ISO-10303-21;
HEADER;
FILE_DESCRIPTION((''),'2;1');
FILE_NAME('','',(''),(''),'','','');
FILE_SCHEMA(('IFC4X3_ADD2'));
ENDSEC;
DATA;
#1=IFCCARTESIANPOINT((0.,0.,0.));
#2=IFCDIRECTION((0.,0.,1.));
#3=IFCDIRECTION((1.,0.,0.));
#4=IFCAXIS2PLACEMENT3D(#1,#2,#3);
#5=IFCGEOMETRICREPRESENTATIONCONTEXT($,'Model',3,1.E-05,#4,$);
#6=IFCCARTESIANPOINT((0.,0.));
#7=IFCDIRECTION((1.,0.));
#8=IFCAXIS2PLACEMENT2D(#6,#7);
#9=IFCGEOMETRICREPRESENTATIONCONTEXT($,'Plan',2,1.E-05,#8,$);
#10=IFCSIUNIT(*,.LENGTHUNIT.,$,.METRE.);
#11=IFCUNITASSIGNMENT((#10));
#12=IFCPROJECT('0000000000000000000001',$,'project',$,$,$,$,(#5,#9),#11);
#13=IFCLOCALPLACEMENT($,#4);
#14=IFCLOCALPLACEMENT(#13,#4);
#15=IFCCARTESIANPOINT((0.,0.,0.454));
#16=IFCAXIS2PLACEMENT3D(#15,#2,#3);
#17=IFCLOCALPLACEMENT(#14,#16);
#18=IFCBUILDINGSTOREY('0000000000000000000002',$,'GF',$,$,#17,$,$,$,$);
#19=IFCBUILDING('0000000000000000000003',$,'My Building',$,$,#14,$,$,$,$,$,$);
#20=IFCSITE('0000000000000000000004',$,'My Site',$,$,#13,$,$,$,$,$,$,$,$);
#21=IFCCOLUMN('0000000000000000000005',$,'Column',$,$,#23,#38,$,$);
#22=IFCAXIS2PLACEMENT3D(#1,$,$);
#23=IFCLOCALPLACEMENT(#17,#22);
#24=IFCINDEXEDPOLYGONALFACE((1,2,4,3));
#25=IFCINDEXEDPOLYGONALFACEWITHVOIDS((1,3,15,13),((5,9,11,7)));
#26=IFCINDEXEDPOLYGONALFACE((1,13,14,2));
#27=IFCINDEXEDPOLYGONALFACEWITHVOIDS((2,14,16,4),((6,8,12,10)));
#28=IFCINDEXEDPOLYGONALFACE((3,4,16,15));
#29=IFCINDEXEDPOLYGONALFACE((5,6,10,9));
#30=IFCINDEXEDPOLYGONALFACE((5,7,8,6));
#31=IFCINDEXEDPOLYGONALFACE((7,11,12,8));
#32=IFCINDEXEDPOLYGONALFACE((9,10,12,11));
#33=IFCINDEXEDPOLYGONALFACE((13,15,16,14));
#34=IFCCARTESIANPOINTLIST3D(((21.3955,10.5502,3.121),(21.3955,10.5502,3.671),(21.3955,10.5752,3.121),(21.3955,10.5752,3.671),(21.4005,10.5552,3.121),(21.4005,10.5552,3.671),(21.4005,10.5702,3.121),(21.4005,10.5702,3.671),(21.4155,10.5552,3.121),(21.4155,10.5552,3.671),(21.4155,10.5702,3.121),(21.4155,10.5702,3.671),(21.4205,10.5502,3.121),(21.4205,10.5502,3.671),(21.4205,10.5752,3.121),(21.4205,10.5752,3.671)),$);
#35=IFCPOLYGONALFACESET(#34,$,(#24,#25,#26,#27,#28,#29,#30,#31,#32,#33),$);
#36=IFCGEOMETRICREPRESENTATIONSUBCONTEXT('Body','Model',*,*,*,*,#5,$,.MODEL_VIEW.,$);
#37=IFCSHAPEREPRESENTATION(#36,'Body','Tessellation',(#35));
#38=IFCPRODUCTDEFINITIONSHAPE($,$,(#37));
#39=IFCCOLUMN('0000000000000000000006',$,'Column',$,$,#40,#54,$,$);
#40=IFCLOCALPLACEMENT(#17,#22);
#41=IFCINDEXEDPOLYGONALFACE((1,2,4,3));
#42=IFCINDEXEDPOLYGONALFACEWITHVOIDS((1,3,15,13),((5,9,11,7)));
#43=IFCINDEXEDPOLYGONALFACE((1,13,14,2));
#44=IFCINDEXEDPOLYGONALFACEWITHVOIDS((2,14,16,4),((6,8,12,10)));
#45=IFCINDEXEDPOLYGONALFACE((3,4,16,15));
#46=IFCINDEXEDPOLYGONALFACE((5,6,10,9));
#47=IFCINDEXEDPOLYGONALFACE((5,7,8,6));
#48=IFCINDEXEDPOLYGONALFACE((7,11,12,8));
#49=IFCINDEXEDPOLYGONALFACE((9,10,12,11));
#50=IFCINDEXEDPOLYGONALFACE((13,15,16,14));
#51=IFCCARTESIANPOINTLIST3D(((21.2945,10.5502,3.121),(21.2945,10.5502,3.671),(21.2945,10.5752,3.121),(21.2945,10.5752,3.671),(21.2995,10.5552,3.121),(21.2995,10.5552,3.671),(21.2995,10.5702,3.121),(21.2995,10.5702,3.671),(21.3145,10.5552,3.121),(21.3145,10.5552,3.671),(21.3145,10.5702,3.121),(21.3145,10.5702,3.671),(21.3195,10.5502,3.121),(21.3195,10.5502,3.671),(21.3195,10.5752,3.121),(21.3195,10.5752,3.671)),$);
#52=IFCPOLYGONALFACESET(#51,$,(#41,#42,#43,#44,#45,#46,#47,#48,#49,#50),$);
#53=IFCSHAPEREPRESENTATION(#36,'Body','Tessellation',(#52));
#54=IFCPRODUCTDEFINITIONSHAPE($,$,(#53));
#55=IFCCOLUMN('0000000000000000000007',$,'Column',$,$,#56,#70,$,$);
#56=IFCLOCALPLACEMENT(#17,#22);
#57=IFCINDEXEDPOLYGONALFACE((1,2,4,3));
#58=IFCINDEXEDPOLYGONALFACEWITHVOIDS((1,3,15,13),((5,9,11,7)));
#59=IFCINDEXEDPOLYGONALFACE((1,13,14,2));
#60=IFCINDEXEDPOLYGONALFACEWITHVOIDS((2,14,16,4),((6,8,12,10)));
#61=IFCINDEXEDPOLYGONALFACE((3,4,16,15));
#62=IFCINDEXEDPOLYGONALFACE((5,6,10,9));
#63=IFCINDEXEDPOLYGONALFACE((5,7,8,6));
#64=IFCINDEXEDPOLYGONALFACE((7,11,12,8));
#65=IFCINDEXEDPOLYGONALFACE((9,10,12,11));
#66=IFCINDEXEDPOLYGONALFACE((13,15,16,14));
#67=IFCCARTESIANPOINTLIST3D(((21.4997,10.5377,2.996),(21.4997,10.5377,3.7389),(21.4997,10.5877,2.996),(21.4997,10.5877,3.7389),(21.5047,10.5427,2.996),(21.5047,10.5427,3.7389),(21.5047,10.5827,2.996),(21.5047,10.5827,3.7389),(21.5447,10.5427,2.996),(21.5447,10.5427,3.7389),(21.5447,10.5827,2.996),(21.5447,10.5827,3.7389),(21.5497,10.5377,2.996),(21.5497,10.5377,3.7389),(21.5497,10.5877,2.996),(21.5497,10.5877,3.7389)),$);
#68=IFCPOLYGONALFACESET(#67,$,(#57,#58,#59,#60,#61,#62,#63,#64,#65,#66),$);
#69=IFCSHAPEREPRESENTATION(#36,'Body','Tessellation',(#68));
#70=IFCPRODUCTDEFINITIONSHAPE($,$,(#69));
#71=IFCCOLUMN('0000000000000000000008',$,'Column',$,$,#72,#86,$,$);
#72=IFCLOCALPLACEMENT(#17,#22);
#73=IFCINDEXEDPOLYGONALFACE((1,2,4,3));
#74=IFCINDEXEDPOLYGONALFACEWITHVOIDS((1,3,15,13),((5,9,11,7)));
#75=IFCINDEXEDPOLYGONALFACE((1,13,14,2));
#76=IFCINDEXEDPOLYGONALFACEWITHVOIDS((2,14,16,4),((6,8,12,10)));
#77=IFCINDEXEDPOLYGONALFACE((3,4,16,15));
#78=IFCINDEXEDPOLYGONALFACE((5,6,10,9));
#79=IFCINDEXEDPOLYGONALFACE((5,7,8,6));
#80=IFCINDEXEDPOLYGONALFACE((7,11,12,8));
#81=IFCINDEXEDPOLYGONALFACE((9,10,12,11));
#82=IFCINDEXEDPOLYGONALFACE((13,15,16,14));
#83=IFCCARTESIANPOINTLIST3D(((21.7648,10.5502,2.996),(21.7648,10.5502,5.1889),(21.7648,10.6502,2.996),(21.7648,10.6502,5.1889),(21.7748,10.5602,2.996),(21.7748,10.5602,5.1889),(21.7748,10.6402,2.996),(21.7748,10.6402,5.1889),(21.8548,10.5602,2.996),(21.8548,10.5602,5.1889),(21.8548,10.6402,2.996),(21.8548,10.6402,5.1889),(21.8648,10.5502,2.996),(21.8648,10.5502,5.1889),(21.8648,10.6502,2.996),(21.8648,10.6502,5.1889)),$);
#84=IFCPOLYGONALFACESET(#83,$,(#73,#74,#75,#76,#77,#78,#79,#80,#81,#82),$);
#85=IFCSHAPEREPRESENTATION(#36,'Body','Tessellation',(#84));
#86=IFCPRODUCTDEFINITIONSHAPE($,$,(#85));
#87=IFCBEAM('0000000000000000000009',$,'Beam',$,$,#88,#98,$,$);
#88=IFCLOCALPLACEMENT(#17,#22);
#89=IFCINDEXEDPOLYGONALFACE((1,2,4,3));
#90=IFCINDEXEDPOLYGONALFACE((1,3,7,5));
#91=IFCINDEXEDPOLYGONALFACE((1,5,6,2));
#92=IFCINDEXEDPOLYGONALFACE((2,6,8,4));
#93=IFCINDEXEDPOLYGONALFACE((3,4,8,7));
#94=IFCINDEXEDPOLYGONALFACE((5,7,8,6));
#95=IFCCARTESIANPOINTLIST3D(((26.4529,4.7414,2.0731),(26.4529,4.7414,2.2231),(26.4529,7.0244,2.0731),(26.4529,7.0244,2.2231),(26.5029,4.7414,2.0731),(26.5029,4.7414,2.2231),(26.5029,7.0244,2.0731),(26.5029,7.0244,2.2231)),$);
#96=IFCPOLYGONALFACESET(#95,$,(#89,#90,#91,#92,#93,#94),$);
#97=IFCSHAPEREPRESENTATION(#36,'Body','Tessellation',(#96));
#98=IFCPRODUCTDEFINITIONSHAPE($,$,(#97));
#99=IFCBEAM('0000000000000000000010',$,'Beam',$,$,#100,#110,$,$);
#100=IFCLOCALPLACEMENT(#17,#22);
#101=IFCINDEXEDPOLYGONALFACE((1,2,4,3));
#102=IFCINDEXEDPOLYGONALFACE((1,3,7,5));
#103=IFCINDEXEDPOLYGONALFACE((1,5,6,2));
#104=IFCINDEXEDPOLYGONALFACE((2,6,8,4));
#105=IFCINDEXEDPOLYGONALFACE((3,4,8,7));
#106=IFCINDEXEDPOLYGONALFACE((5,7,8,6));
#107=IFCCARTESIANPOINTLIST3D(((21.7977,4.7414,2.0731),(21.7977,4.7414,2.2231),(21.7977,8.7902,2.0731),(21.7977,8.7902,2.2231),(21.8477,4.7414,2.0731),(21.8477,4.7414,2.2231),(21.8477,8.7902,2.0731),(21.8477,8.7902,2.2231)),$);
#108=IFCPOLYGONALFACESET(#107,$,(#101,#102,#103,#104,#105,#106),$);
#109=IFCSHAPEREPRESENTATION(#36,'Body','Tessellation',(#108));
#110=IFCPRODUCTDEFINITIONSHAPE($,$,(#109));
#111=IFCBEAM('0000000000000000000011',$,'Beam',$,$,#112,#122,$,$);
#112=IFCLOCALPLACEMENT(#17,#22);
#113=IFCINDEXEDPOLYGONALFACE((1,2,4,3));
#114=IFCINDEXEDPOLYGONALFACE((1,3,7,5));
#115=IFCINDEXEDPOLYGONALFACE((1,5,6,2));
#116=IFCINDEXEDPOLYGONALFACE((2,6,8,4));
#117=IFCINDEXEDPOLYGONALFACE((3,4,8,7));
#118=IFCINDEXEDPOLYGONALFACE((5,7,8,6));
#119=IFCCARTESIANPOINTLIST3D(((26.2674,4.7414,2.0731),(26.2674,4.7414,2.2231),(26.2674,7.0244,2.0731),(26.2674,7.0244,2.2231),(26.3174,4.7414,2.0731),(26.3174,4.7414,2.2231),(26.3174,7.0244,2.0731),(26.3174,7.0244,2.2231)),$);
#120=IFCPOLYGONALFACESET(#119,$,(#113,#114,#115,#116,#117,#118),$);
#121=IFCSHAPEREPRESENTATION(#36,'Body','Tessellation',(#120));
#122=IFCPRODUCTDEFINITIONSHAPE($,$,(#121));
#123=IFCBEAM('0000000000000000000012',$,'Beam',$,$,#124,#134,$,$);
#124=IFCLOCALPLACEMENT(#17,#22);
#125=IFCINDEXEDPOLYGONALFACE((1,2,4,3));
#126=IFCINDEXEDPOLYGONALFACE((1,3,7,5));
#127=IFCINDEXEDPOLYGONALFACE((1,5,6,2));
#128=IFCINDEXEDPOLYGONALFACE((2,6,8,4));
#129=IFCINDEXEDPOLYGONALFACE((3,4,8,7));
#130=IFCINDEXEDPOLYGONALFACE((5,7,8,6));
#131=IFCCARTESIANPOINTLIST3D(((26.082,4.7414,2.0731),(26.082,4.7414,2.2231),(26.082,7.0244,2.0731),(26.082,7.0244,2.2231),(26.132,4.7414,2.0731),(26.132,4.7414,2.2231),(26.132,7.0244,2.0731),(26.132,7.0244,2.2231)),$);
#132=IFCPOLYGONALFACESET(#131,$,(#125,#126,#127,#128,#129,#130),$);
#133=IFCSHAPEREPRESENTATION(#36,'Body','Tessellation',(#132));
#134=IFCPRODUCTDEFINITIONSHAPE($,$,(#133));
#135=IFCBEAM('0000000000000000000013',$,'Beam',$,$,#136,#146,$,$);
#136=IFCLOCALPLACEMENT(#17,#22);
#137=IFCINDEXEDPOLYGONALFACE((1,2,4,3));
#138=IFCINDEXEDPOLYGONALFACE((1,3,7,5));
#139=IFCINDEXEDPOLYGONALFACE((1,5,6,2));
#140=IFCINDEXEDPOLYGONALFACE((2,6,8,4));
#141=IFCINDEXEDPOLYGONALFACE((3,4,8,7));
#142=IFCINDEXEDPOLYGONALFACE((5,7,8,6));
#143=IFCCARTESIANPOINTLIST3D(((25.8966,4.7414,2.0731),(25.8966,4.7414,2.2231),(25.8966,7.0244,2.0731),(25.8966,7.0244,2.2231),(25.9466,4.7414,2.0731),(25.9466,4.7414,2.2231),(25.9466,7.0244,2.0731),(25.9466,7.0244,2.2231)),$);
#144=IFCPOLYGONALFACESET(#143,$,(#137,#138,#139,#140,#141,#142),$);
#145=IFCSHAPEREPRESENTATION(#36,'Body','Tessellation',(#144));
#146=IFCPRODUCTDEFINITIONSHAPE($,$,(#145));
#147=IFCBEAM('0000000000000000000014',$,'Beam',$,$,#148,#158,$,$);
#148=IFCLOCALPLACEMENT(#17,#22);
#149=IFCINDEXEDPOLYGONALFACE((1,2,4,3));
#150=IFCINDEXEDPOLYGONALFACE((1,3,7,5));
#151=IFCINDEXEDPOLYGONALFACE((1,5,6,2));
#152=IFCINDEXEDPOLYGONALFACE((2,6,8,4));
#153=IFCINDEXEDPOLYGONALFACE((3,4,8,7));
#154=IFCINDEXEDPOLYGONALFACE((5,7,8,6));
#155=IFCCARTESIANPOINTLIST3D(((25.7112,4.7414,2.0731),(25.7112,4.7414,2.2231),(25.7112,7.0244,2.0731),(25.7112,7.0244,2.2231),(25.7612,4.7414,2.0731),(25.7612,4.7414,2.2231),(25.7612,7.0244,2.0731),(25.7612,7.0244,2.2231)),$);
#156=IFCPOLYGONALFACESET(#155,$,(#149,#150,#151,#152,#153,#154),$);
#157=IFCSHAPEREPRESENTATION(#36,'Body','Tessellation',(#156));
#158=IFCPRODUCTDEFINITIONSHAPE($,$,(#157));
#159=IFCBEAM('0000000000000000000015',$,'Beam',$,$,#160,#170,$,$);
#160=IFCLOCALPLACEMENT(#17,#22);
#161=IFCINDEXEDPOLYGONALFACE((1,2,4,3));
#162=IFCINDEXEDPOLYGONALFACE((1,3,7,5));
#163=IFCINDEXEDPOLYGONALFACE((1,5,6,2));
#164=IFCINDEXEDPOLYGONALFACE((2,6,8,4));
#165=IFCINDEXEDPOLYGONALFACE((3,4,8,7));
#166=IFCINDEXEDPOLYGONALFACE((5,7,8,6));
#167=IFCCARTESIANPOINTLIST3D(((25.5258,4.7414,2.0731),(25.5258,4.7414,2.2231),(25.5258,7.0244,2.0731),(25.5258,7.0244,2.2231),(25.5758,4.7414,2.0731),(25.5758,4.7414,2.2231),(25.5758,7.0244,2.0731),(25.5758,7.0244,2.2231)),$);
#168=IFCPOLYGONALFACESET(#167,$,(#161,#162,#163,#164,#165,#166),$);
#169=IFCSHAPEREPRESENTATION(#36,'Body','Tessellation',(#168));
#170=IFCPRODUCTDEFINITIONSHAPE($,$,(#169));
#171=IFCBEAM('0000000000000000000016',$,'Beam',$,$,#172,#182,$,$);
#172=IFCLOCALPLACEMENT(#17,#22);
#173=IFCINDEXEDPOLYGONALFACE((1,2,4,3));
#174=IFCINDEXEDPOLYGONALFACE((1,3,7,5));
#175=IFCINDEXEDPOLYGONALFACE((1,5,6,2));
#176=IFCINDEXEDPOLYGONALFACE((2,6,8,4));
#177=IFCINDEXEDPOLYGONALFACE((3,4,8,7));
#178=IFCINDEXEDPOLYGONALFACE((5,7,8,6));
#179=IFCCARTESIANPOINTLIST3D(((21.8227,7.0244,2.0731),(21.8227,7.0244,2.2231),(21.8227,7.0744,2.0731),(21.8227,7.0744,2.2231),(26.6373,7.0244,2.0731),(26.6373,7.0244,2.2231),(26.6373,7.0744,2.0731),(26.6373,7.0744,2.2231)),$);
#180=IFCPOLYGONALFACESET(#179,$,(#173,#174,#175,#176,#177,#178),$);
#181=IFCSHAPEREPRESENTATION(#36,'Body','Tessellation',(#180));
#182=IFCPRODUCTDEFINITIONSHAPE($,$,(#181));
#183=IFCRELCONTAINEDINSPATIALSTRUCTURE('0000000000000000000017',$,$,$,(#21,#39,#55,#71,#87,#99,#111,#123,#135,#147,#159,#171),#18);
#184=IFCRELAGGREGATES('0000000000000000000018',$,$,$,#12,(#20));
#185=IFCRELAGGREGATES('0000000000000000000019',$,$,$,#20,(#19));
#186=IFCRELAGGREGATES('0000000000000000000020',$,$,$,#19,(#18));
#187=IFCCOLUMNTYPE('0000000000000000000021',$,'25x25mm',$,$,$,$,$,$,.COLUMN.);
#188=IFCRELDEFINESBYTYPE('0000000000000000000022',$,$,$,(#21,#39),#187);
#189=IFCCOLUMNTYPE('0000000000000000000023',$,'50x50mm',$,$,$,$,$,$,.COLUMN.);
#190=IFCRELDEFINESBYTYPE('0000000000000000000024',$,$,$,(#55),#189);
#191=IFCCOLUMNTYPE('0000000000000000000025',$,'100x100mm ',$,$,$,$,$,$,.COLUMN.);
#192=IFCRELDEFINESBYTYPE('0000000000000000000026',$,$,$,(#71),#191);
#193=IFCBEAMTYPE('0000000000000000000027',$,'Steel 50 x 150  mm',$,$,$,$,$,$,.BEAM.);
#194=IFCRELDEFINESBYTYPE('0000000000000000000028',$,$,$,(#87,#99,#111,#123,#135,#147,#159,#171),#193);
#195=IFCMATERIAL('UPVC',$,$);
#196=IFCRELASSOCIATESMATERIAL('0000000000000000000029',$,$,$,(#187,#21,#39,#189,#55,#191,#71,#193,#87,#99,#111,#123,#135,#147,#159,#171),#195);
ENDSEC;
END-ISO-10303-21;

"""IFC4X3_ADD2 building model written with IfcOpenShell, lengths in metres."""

from ifc_helpers import new_model, si_unit, frame, origin_with_axes, origin_2d_with_axis, place, context, subcontext, project, spatial, rectangle, hollow_rectangle, extrude, material, material_profile, profile_set, profile_usage, type_object, element, save


model = new_model("IFC4X3_ADD2")

# Units and contexts
model_context = context("Model", 3, precision=1e-05, world=origin_with_axes())
plan_context = context("Plan", 2, precision=1e-05, world=origin_2d_with_axis())
body_context = subcontext(model_context, "Body", "Model", "MODEL_VIEW")
ifc_project = project(units=[si_unit("LENGTHUNIT", "METRE")], contexts=[model_context, plan_context])

# Site, building, storey
site_placement = place(None, origin_with_axes())
site = spatial("IfcSite", under=ifc_project, at=site_placement, Name="My Site")
building_placement = place(site_placement, origin_with_axes())
building = spatial("IfcBuilding", under=site, at=building_placement, Name="My Building")
storey_placement = place(building_placement, frame((0.0, 0.0, 0.454), z_axis=(0.0, 0.0, 1.0), x_axis=(1.0, 0.0, 0.0)))
storey = spatial("IfcBuildingStorey", under=building, at=storey_placement, Name="GF")

# Columns
ifc_material_1 = material(Name="UPVC")
ifc_material_profile_1 = material_profile(ifc_material_1, hollow_rectangle(XDim=0.025, YDim=0.025, WallThickness=0.005))
ifc_profile_set_1 = profile_set([ifc_material_profile_1])
ifc_profile_usage_1 = profile_usage(ifc_profile_set_1)
column_type_1 = type_object("IfcColumnType", Name="25x25mm", PredefinedType="COLUMN", material=ifc_profile_set_1)
column_1_placement = place(storey_placement, frame((21.408, 10.5627, 3.121), z_axis=(0.0, 0.0, 1.0), x_axis=(0.0, -1.0, 0.0)))
element("IfcColumn", 1, at=column_1_placement, inside=storey, type_object=column_type_1, material=ifc_profile_usage_1, Name="Column", context=body_context, shape_type="SweptSolid", body=[
    extrude(hollow_rectangle(XDim=0.025, YDim=0.025, WallThickness=0.005), origin_with_axes(), (0.0, 0.0, 1.0), 0.55),
])
ifc_profile_usage_2 = profile_usage(ifc_profile_set_1)
column_2_placement = place(storey_placement, frame((21.307, 10.5627, 3.121), z_axis=(0.0, 0.0, 1.0), x_axis=(0.0, -1.0, 0.0)))
element("IfcColumn", 2, at=column_2_placement, inside=storey, type_object=column_type_1, material=ifc_profile_usage_2, Name="Column", context=body_context, shape_type="SweptSolid", body=[
    extrude(hollow_rectangle(XDim=0.025, YDim=0.025, WallThickness=0.005), origin_with_axes(), (0.0, 0.0, 1.0), 0.55),
])
ifc_material_profile_2 = material_profile(ifc_material_1, hollow_rectangle(XDim=0.05, YDim=0.05, WallThickness=0.005))
ifc_profile_set_2 = profile_set([ifc_material_profile_2])
ifc_profile_usage_3 = profile_usage(ifc_profile_set_2)
column_type_2 = type_object("IfcColumnType", Name="50x50mm", PredefinedType="COLUMN", material=ifc_profile_set_2)
column_3_placement = place(storey_placement, frame((21.5247, 10.5627, 2.996), z_axis=(0.0, 0.0, 1.0), x_axis=(1.0, 0.0, 0.0)))
element("IfcColumn", 3, at=column_3_placement, inside=storey, type_object=column_type_2, material=ifc_profile_usage_3, Name="Column", context=body_context, shape_type="SweptSolid", body=[
    extrude(hollow_rectangle(XDim=0.05, YDim=0.05, WallThickness=0.005), origin_with_axes(), (0.0, 0.0, 1.0), 0.7429),
])
ifc_material_profile_3 = material_profile(ifc_material_1, hollow_rectangle(XDim=0.1, YDim=0.1, WallThickness=0.01))
ifc_profile_set_3 = profile_set([ifc_material_profile_3])
ifc_profile_usage_4 = profile_usage(ifc_profile_set_3)
column_type_3 = type_object("IfcColumnType", Name="100x100mm ", PredefinedType="COLUMN", material=ifc_profile_set_3)
column_4_placement = place(storey_placement, frame((21.8148, 10.6002, 2.996), z_axis=(0.0, 0.0, 1.0), x_axis=(0.0, -1.0, 0.0)))
element("IfcColumn", 4, at=column_4_placement, inside=storey, type_object=column_type_3, material=ifc_profile_usage_4, Name="Column", context=body_context, shape_type="SweptSolid", body=[
    extrude(hollow_rectangle(XDim=0.1, YDim=0.1, WallThickness=0.01), origin_with_axes(), (0.0, 0.0, 1.0), 2.1929),
])

# Beams
ifc_material_profile_4 = material_profile(ifc_material_1, rectangle(XDim=0.05, YDim=0.15))
ifc_profile_set_4 = profile_set([ifc_material_profile_4])
ifc_profile_usage_5 = profile_usage(ifc_profile_set_4)
beam_type = type_object("IfcBeamType", Name="Steel 50 x 150  mm", PredefinedType="BEAM", material=ifc_profile_set_4)
beam_1_placement = place(storey_placement, frame((26.4779, 7.0244, 2.1481), z_axis=(0.0, -1.0, 0.0), x_axis=(1.0, 0.0, 0.0)))
element("IfcBeam", 5, at=beam_1_placement, inside=storey, type_object=beam_type, material=ifc_profile_usage_5, Name="Beam", context=body_context, shape_type="SweptSolid", body=[
    extrude(rectangle(XDim=0.05, YDim=0.15), origin_with_axes(), (0.0, 0.0, 1.0), 2.283),
])
ifc_profile_usage_6 = profile_usage(ifc_profile_set_4)
beam_2_placement = place(storey_placement, frame((21.8227, 8.7902, 2.1481), z_axis=(0.0, -1.0, 0.0), x_axis=(1.0, 0.0, 0.0)))
element("IfcBeam", 6, at=beam_2_placement, inside=storey, type_object=beam_type, material=ifc_profile_usage_6, Name="Beam", context=body_context, shape_type="SweptSolid", body=[
    extrude(rectangle(XDim=0.05, YDim=0.15), origin_with_axes(), (0.0, 0.0, 1.0), 4.0488),
])
ifc_profile_usage_7 = profile_usage(ifc_profile_set_4)
beam_3_placement = place(storey_placement, frame((26.2924, 7.0244, 2.1481), z_axis=(0.0, -1.0, 0.0), x_axis=(1.0, 0.0, 0.0)))
element("IfcBeam", 7, at=beam_3_placement, inside=storey, type_object=beam_type, material=ifc_profile_usage_7, Name="Beam", context=body_context, shape_type="SweptSolid", body=[
    extrude(rectangle(XDim=0.05, YDim=0.15), origin_with_axes(), (0.0, 0.0, 1.0), 2.283),
])
ifc_profile_usage_8 = profile_usage(ifc_profile_set_4)
beam_4_placement = place(storey_placement, frame((26.107, 7.0244, 2.1481), z_axis=(0.0, -1.0, 0.0), x_axis=(1.0, 0.0, 0.0)))
element("IfcBeam", 8, at=beam_4_placement, inside=storey, type_object=beam_type, material=ifc_profile_usage_8, Name="Beam", context=body_context, shape_type="SweptSolid", body=[
    extrude(rectangle(XDim=0.05, YDim=0.15), origin_with_axes(), (0.0, 0.0, 1.0), 2.283),
])
ifc_profile_usage_9 = profile_usage(ifc_profile_set_4)
beam_5_placement = place(storey_placement, frame((25.9216, 7.0244, 2.1481), z_axis=(0.0, -1.0, 0.0), x_axis=(1.0, 0.0, 0.0)))
element("IfcBeam", 9, at=beam_5_placement, inside=storey, type_object=beam_type, material=ifc_profile_usage_9, Name="Beam", context=body_context, shape_type="SweptSolid", body=[
    extrude(rectangle(XDim=0.05, YDim=0.15), origin_with_axes(), (0.0, 0.0, 1.0), 2.283),
])
ifc_profile_usage_10 = profile_usage(ifc_profile_set_4)
beam_6_placement = place(storey_placement, frame((25.7362, 7.0244, 2.1481), z_axis=(0.0, -1.0, 0.0), x_axis=(1.0, 0.0, 0.0)))
element("IfcBeam", 10, at=beam_6_placement, inside=storey, type_object=beam_type, material=ifc_profile_usage_10, Name="Beam", context=body_context, shape_type="SweptSolid", body=[
    extrude(rectangle(XDim=0.05, YDim=0.15), origin_with_axes(), (0.0, 0.0, 1.0), 2.283),
])
ifc_profile_usage_11 = profile_usage(ifc_profile_set_4)
beam_7_placement = place(storey_placement, frame((25.5508, 7.0244, 2.1481), z_axis=(0.0, -1.0, 0.0), x_axis=(1.0, 0.0, 0.0)))
element("IfcBeam", 11, at=beam_7_placement, inside=storey, type_object=beam_type, material=ifc_profile_usage_11, Name="Beam", context=body_context, shape_type="SweptSolid", body=[
    extrude(rectangle(XDim=0.05, YDim=0.15), origin_with_axes(), (0.0, 0.0, 1.0), 2.283),
])
ifc_profile_usage_12 = profile_usage(ifc_profile_set_4)
beam_8_placement = place(storey_placement, frame((21.8227, 7.0494, 2.1481), z_axis=(1.0, 0.0, 0.0), x_axis=(0.0, 1.0, 0.0)))
element("IfcBeam", 12, at=beam_8_placement, inside=storey, type_object=beam_type, material=ifc_profile_usage_12, Name="Beam", context=body_context, shape_type="SweptSolid", body=[
    extrude(rectangle(XDim=0.05, YDim=0.15), origin_with_axes(), (0.0, 0.0, 1.0), 4.8146),
])

save(model, "model.ifc")
